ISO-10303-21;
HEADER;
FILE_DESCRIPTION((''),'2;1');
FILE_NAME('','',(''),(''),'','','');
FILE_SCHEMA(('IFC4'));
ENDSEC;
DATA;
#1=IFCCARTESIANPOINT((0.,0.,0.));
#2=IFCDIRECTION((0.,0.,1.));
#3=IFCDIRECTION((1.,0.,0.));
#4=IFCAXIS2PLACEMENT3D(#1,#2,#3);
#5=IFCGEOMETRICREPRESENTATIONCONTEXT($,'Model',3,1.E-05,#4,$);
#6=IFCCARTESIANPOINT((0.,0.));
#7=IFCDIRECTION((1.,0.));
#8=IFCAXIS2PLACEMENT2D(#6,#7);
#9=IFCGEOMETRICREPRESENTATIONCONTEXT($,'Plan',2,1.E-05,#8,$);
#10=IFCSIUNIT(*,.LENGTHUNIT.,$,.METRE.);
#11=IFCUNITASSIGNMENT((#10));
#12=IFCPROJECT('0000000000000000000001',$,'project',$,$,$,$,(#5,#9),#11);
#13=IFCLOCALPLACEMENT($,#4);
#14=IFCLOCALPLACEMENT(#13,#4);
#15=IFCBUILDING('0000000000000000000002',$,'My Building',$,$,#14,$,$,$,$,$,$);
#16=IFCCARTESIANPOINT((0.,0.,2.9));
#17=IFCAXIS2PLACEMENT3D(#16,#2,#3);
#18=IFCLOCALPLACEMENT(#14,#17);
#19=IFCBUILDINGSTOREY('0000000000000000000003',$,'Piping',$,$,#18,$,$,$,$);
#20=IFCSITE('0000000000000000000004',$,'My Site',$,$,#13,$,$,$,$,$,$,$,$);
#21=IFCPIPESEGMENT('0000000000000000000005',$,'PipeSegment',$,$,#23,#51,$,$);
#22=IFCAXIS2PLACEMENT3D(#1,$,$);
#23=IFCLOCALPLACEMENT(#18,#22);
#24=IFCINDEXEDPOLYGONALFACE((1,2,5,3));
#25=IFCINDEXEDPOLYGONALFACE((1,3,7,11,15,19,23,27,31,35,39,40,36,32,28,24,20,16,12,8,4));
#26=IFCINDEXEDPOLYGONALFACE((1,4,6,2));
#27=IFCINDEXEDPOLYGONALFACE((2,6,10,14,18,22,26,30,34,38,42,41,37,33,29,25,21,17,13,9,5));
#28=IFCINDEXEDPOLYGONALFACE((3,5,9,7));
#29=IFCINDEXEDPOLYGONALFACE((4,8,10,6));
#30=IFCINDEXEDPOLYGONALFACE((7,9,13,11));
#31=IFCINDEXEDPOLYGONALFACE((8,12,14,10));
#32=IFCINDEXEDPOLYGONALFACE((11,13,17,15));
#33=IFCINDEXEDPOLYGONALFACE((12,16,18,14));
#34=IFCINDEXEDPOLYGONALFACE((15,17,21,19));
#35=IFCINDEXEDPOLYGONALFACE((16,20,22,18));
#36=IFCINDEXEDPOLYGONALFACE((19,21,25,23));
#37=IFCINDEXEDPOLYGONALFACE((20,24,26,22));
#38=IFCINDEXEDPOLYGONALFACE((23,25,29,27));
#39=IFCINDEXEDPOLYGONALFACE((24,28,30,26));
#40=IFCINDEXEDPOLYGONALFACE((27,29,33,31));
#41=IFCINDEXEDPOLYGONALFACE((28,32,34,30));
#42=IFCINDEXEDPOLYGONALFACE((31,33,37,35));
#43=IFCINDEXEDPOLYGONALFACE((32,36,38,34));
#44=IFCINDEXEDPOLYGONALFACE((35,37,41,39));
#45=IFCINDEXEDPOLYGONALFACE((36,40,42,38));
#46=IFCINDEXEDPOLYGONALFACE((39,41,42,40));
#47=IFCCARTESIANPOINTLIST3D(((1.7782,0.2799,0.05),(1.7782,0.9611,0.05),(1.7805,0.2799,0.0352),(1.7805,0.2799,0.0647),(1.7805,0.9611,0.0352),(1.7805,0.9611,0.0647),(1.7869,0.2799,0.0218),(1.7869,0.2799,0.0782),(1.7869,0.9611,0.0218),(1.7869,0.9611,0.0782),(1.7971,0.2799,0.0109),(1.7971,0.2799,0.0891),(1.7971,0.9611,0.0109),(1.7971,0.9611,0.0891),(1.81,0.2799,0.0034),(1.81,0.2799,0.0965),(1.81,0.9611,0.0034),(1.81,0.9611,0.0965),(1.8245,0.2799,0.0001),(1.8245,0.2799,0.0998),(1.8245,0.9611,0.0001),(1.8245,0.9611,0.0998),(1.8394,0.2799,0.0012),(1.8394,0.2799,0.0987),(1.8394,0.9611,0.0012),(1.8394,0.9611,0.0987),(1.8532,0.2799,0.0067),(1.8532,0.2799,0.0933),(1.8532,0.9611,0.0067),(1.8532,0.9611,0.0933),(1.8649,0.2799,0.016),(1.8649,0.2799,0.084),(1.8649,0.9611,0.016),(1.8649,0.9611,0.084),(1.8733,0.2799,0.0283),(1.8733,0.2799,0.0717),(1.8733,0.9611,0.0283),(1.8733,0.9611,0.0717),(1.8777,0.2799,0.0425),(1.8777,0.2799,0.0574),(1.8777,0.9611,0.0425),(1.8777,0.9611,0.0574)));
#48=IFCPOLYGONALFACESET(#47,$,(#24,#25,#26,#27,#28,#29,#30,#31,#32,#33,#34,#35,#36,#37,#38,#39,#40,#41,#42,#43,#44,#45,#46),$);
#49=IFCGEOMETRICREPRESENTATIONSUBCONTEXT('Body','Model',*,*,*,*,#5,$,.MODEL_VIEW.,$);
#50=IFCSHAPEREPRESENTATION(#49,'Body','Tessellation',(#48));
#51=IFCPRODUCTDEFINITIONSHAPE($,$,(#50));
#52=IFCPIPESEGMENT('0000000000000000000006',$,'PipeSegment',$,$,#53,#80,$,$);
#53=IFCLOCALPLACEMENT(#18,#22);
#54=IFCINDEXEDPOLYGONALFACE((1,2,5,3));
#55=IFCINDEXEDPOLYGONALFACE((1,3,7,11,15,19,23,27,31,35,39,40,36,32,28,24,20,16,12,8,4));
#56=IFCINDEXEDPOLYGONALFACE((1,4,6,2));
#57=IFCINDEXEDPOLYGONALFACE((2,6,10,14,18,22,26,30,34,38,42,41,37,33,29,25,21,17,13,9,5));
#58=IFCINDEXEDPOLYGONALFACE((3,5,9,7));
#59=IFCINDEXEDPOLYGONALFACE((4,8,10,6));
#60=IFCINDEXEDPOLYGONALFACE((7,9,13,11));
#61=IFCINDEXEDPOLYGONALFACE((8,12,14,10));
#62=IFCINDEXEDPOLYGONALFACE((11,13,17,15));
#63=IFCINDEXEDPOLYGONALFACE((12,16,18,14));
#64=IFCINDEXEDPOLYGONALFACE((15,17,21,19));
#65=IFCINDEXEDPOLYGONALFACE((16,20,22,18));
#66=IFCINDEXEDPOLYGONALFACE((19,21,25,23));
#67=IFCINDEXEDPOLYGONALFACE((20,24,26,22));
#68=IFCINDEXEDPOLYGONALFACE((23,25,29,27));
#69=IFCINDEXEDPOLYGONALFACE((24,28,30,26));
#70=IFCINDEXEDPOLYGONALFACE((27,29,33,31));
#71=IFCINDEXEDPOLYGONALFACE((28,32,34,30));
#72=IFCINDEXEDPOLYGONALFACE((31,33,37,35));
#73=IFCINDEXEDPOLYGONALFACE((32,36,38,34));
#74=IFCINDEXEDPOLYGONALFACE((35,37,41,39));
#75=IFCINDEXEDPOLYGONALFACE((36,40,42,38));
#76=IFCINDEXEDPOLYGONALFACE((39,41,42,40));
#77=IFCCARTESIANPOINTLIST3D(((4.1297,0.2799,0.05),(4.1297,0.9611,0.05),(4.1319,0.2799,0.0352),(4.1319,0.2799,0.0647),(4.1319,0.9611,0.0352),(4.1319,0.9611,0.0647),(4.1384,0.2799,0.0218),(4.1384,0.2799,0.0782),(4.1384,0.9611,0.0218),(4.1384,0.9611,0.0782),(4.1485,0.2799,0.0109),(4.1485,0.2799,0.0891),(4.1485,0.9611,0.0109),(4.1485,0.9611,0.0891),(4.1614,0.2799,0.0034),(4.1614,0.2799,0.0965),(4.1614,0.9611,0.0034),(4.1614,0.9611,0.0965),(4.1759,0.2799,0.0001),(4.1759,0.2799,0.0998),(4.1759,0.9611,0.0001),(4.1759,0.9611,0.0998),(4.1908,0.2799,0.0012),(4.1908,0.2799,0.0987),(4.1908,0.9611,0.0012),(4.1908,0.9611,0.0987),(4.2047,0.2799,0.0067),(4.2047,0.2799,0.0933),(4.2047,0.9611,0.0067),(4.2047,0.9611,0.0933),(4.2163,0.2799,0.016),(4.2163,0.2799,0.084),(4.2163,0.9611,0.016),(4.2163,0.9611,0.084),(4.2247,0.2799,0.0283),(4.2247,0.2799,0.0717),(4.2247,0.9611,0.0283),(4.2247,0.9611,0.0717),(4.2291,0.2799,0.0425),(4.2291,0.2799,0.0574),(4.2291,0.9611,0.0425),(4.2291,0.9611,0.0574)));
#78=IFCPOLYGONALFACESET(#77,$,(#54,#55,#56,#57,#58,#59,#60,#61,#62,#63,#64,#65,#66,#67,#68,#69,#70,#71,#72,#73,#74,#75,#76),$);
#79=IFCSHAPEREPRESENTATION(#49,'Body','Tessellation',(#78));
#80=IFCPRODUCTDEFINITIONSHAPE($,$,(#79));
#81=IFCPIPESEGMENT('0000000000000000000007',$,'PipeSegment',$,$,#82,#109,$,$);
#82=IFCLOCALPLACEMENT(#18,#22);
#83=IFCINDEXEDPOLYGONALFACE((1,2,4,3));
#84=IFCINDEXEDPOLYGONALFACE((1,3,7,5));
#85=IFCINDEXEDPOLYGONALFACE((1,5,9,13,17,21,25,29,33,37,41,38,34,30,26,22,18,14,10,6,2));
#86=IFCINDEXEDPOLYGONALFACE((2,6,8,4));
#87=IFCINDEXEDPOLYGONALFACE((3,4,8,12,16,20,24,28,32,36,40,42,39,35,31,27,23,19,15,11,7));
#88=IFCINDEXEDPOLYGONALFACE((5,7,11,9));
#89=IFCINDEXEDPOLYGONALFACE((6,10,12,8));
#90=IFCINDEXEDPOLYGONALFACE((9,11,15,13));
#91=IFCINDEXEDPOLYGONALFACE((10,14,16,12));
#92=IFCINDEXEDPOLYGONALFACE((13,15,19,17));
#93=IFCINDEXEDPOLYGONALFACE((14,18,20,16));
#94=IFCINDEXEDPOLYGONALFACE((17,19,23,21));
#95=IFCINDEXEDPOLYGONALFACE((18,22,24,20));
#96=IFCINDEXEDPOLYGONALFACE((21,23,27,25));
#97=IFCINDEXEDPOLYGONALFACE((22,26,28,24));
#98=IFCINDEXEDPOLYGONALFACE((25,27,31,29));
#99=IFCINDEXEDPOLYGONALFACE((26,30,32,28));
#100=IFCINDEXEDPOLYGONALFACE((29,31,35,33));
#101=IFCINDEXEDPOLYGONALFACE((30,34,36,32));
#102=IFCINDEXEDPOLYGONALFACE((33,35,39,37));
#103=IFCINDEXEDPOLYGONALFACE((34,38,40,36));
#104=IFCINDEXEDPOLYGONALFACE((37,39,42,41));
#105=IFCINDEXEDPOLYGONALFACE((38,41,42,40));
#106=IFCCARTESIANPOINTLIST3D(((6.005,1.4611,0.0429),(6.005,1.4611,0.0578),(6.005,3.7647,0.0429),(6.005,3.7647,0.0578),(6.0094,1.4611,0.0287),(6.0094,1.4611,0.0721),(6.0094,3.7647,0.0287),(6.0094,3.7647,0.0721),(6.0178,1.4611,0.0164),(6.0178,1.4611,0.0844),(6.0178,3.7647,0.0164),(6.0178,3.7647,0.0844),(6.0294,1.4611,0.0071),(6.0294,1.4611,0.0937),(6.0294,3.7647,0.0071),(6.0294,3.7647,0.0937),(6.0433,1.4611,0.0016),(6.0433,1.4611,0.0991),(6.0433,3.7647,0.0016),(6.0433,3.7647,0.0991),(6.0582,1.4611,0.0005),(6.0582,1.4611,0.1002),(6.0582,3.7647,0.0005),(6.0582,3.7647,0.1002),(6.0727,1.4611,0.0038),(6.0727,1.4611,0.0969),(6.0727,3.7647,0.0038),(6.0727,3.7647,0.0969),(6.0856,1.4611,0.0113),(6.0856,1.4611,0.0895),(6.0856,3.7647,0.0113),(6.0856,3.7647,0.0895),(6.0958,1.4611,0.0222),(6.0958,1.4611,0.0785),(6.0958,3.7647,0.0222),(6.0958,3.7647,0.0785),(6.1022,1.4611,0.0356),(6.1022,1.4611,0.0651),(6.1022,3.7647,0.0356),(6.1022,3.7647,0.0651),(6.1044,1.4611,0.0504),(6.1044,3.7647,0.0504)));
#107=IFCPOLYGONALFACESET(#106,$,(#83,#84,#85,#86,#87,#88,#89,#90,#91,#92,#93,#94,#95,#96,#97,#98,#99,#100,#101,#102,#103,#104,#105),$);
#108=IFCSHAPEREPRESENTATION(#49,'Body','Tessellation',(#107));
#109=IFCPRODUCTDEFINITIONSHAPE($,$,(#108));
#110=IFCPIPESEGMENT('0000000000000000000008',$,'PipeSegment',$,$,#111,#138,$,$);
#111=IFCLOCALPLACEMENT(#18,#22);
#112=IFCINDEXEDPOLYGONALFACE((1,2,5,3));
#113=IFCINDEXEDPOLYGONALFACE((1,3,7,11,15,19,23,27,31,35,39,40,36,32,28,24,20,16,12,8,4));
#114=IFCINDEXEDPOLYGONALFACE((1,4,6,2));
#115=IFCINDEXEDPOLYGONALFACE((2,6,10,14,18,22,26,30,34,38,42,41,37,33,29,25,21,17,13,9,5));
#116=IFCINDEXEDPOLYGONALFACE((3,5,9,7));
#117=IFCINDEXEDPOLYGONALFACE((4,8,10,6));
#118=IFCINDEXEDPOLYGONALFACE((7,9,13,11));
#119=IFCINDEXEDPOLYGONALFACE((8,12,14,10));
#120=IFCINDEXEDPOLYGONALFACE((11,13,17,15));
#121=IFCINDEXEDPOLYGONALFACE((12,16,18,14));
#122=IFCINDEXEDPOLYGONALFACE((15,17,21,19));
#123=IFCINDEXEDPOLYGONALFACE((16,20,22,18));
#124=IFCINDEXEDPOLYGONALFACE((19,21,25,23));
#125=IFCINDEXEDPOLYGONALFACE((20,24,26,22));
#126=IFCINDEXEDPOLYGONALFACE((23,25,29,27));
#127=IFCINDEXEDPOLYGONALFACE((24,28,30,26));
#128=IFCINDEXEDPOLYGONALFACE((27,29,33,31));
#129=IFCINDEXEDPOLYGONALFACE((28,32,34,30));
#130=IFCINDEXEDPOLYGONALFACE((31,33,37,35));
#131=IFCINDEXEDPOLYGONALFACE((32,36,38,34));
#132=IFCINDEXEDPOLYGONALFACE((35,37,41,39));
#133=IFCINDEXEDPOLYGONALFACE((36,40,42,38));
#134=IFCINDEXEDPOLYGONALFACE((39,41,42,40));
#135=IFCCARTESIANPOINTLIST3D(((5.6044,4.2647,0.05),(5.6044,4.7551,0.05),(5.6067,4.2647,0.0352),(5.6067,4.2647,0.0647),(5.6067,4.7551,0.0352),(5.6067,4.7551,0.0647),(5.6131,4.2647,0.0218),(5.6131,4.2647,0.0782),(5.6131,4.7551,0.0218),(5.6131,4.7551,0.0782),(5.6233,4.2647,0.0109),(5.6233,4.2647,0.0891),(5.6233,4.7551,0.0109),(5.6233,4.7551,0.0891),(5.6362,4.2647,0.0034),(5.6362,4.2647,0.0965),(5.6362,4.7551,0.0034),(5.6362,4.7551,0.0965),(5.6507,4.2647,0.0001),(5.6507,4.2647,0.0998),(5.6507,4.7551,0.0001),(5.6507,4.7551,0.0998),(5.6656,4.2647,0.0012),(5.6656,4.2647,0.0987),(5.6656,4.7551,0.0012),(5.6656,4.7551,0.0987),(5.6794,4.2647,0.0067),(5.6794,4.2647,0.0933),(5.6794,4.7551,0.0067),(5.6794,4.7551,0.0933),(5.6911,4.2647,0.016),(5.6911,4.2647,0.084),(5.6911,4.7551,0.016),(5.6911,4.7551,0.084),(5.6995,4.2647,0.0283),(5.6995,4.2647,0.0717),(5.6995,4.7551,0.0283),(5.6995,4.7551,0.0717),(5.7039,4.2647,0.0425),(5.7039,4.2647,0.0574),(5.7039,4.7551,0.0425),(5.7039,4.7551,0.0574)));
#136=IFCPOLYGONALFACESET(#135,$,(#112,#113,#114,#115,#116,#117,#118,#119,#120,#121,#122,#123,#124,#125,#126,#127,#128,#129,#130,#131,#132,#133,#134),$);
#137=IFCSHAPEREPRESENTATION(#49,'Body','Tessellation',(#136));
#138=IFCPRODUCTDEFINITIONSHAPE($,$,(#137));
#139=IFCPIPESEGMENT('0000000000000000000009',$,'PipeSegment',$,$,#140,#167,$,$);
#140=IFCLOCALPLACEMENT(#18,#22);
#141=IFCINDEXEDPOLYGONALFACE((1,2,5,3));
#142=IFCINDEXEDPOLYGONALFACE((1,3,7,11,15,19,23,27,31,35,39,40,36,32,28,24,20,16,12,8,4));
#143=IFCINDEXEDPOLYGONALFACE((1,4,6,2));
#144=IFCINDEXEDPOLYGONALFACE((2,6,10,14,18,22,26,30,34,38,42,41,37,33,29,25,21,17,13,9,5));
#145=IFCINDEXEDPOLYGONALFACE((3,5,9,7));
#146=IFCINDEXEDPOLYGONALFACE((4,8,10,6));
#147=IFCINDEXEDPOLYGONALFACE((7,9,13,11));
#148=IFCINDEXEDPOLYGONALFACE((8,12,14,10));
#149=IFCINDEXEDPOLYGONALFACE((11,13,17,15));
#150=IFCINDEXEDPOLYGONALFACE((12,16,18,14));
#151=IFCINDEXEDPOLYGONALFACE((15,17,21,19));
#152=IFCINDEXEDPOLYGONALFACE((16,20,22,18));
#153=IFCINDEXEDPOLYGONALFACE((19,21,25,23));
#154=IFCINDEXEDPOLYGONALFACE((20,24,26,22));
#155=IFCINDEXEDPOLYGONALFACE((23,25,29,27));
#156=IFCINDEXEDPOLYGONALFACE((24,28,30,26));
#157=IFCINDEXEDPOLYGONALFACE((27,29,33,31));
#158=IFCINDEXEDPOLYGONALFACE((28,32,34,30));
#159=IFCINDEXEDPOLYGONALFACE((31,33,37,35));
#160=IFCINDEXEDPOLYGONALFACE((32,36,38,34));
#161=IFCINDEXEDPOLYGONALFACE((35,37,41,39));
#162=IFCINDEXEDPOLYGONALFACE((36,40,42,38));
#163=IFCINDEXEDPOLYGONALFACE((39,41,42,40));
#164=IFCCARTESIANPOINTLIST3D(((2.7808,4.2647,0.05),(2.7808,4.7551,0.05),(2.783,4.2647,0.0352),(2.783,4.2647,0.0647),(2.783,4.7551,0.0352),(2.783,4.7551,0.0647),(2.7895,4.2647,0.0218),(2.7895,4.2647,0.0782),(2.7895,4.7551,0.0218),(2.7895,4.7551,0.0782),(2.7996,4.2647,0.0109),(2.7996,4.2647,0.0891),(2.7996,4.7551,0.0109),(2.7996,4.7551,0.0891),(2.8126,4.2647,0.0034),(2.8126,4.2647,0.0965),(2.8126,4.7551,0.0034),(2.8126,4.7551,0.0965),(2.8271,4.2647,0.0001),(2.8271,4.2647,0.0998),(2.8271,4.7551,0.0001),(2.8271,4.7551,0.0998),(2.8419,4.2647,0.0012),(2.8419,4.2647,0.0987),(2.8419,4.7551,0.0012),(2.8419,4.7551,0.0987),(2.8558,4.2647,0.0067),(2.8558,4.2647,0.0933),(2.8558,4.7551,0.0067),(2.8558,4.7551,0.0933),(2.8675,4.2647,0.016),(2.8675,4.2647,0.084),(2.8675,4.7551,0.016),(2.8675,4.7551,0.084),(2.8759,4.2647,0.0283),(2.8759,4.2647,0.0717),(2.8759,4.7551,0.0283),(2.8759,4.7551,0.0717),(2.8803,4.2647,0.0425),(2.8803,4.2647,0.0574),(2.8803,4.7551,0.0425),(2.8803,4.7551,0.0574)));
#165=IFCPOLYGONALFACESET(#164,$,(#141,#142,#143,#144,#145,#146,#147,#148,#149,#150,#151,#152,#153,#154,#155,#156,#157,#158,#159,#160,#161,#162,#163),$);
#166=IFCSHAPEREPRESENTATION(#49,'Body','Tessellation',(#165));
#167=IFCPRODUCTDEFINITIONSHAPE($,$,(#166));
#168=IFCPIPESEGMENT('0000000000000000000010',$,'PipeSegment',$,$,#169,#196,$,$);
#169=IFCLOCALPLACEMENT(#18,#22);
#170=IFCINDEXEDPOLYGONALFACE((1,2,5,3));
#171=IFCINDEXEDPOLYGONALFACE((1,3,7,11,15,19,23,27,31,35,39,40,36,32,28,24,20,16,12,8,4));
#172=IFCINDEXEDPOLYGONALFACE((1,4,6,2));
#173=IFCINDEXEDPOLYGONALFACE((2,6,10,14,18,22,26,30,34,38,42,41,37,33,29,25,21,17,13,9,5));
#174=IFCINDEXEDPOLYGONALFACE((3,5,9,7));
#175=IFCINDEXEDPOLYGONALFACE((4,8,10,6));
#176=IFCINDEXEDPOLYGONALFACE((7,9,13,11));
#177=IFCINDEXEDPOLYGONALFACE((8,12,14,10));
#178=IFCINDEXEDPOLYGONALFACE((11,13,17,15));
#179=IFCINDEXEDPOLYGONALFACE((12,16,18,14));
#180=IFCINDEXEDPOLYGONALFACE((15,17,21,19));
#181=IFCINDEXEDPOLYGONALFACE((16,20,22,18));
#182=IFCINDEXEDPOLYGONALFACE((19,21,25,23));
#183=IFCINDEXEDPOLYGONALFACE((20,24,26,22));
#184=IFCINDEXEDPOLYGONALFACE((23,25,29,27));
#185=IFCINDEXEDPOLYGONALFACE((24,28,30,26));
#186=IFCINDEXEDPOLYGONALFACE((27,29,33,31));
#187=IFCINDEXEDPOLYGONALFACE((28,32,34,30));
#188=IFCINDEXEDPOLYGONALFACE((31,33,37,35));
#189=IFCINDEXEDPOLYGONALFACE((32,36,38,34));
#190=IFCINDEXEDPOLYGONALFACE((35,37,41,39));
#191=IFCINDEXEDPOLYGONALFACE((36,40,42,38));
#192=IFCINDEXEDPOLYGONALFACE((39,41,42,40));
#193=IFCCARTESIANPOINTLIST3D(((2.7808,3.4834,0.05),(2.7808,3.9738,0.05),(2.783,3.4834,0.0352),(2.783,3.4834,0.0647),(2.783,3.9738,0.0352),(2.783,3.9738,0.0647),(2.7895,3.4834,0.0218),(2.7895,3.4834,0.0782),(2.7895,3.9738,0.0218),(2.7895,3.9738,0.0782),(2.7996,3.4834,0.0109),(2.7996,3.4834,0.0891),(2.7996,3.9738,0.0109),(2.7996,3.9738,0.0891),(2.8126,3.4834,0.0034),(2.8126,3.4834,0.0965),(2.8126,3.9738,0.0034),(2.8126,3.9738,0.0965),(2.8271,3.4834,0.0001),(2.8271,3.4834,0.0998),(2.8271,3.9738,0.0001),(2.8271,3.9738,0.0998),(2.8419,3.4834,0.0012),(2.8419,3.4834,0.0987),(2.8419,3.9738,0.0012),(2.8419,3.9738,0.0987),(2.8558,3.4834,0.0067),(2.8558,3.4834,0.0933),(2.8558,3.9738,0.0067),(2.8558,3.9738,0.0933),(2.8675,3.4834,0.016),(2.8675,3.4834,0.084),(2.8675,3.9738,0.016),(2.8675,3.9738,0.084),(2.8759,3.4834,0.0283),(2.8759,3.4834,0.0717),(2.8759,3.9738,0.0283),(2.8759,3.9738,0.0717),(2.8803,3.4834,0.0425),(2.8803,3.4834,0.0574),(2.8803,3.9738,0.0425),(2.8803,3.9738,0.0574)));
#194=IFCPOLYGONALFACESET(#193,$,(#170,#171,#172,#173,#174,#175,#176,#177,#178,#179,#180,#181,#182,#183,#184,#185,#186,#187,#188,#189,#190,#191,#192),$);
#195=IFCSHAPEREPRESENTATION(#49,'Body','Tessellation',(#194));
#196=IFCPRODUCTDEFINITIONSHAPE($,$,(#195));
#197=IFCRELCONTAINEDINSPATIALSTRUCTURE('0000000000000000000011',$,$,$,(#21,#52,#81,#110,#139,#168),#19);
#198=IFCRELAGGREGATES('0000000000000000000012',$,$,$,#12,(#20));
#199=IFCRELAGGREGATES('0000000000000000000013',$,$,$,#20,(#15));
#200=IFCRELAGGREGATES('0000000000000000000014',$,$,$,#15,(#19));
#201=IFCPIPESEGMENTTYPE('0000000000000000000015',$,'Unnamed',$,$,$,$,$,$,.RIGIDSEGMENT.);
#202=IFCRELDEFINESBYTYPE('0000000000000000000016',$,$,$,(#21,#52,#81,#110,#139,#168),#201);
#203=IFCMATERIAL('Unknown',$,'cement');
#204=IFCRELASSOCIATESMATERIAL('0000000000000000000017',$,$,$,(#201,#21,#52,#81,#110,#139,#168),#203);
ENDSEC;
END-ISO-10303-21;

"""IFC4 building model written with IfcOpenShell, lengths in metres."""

from ifc_helpers import new_model, si_unit, frame, origin_with_axes, origin_2d_with_axis, place, context, subcontext, project, spatial, circle, extrude, material, material_profile, profile_set, profile_usage, type_object, element, save


model = new_model("IFC4")

# Units and contexts
model_context = context("Model", 3, precision=1e-05, world=origin_with_axes())
plan_context = context("Plan", 2, precision=1e-05, world=origin_2d_with_axis())
body_context = subcontext(model_context, "Body", "Model", "MODEL_VIEW")
ifc_project = project(units=[si_unit("LENGTHUNIT", "METRE")], contexts=[model_context, plan_context])

# Site, building, storey
site_placement = place(None, origin_with_axes())
site = spatial("IfcSite", under=ifc_project, at=site_placement, Name="My Site")
building_placement = place(site_placement, origin_with_axes())
building = spatial("IfcBuilding", under=site, at=building_placement, Name="My Building")
storey_placement = place(building_placement, frame((0.0, 0.0, 2.9), z_axis=(0.0, 0.0, 1.0), x_axis=(1.0, 0.0, 0.0)))
storey = spatial("IfcBuildingStorey", under=building, at=storey_placement, Name="Piping")

# Pipe segments
ifc_material = material(Name="Unknown", Category="cement")
ifc_material_profile_1 = material_profile(ifc_material, circle(Radius=0.05))
ifc_profile_set_1 = profile_set([ifc_material_profile_1])
ifc_profile_usage_1 = profile_usage(ifc_profile_set_1, cardinal=5)
pipe_segment_type = type_object("IfcPipeSegmentType", Name="Unnamed", PredefinedType="RIGIDSEGMENT", material=ifc_profile_set_1)
pipe_segment_1_placement = place(storey_placement, frame((1.8282, 0.2799, 0.05), z_axis=(0.0, 1.0, 0.0), x_axis=(-1.0, 0.0, 0.0)))
element("IfcPipeSegment", 1, at=pipe_segment_1_placement, inside=storey, type_object=pipe_segment_type, material=ifc_profile_usage_1, Name="PipeSegment", context=body_context, shape_type="SweptSolid", body=[
    extrude(circle(Radius=0.05), origin_with_axes(), (0.0, 0.0, 1.0), 0.6812),
])
ifc_profile_usage_2 = profile_usage(ifc_profile_set_1, cardinal=5)
pipe_segment_2_placement = place(storey_placement, frame((4.1797, 0.2799, 0.05), z_axis=(0.0, 1.0, 0.0), x_axis=(-1.0, 0.0, 0.0)))
element("IfcPipeSegment", 2, at=pipe_segment_2_placement, inside=storey, type_object=pipe_segment_type, material=ifc_profile_usage_2, Name="PipeSegment", context=body_context, shape_type="SweptSolid", body=[
    extrude(circle(Radius=0.05), origin_with_axes(), (0.0, 0.0, 1.0), 0.6812),
])
ifc_profile_usage_3 = profile_usage(ifc_profile_set_1, cardinal=5)
pipe_segment_3_placement = place(storey_placement, frame((6.0544, 3.7647, 0.0504), z_axis=(0.0, -1.0, 0.0), x_axis=(1.0, 0.0, 0.0)))
element("IfcPipeSegment", 3, at=pipe_segment_3_placement, inside=storey, type_object=pipe_segment_type, material=ifc_profile_usage_3, Name="PipeSegment", context=body_context, shape_type="SweptSolid", body=[
    extrude(circle(Radius=0.05), origin_with_axes(), (0.0, 0.0, 1.0), 2.3036),
])
ifc_profile_usage_4 = profile_usage(ifc_profile_set_1, cardinal=5)
pipe_segment_4_placement = place(storey_placement, frame((5.6544, 4.2647, 0.05), z_axis=(0.0, 1.0, 0.0), x_axis=(-1.0, 0.0, 0.0)))
element("IfcPipeSegment", 4, at=pipe_segment_4_placement, inside=storey, type_object=pipe_segment_type, material=ifc_profile_usage_4, Name="PipeSegment", context=body_context, shape_type="SweptSolid", body=[
    extrude(circle(Radius=0.05), origin_with_axes(), (0.0, 0.0, 1.0), 0.4905),
])
ifc_profile_usage_5 = profile_usage(ifc_profile_set_1, cardinal=5)
pipe_segment_5_placement = place(storey_placement, frame((2.8308, 4.2647, 0.05), z_axis=(0.0, 1.0, 0.0), x_axis=(-1.0, 0.0, 0.0)))
element("IfcPipeSegment", 5, at=pipe_segment_5_placement, inside=storey, type_object=pipe_segment_type, material=ifc_profile_usage_5, Name="PipeSegment", context=body_context, shape_type="SweptSolid", body=[
    extrude(circle(Radius=0.05), origin_with_axes(), (0.0, 0.0, 1.0), 0.4905),
])
ifc_profile_usage_6 = profile_usage(ifc_profile_set_1, cardinal=5)
pipe_segment_6_placement = place(storey_placement, frame((2.8308, 3.4834, 0.05), z_axis=(0.0, 1.0, 0.0), x_axis=(-1.0, 0.0, 0.0)))
element("IfcPipeSegment", 6, at=pipe_segment_6_placement, inside=storey, type_object=pipe_segment_type, material=ifc_profile_usage_6, Name="PipeSegment", context=body_context, shape_type="SweptSolid", body=[
    extrude(circle(Radius=0.05), origin_with_axes(), (0.0, 0.0, 1.0), 0.4905),
])

save(model, "model.ifc")
